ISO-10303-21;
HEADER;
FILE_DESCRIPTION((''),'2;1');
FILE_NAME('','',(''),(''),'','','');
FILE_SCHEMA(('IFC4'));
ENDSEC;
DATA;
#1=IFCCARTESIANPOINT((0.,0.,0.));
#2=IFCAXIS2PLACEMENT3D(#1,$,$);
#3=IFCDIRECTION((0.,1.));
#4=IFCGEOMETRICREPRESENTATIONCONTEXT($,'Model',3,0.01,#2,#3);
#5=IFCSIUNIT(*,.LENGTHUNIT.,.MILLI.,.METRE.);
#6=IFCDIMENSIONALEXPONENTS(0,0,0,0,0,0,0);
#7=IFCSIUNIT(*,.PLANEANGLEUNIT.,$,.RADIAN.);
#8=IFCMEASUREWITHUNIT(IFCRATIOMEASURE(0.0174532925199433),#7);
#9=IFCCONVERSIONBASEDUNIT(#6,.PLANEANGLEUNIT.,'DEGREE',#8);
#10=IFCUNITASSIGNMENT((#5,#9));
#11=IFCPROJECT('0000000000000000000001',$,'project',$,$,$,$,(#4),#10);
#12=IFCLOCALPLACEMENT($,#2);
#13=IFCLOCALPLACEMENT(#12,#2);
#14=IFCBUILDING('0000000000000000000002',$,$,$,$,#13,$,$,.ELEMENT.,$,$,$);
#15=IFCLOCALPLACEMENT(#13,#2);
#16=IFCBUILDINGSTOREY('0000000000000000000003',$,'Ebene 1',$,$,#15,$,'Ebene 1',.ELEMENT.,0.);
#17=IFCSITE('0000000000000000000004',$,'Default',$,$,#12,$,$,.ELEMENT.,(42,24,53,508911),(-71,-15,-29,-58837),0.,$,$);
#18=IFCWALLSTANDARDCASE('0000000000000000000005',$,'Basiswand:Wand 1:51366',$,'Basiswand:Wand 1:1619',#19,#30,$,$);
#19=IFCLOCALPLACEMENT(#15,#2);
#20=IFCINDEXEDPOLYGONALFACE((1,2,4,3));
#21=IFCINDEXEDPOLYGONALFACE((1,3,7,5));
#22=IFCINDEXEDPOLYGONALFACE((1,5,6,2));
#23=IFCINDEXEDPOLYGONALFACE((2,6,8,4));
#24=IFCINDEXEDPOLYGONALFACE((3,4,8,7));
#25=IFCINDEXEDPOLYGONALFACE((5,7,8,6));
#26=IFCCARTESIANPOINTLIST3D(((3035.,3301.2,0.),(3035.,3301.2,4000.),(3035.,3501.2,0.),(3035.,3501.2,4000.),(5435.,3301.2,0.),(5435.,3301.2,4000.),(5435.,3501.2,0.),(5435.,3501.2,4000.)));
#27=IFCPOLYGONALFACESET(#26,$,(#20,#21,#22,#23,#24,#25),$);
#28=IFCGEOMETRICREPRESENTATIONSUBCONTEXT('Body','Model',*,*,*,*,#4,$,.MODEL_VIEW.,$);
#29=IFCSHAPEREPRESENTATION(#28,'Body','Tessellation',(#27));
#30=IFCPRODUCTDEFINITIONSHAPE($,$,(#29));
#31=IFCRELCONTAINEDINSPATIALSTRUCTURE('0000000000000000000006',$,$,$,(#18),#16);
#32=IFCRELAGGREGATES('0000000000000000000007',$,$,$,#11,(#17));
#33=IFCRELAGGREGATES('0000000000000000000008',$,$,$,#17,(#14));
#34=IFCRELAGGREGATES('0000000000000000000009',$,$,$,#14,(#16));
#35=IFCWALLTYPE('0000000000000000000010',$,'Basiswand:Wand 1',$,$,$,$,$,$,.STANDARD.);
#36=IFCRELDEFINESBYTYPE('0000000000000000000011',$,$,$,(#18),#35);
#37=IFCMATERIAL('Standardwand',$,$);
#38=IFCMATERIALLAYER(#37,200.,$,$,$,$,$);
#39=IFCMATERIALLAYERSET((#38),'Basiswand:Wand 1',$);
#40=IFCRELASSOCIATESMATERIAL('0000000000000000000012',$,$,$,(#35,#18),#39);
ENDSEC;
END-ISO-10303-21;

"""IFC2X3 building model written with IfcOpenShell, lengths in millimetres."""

from ifc_helpers import new_model, entity, si_unit, converted_unit, direction, frame, frame_2d, origin, place, context, subcontext, project, spatial, rectangle, extrude, material, layer, layer_set, layer_usage, type_object, element, save


model = new_model("IFC2X3")

# Units and contexts
model_context = context("Model", 3, precision=0.01, world=origin(), true_north=direction((0.0, 1.0)))
body_context = subcontext(model_context, "Body", "Model", "MODEL_VIEW")
ifc_project = project(units=[si_unit("LENGTHUNIT", "METRE", prefix="MILLI"), converted_unit("PLANEANGLEUNIT", "DEGREE", entity("IfcRatioMeasure", 0.0174532925199433), si_unit("PLANEANGLEUNIT", "RADIAN"), dimensions=[0, 0, 0, 0, 0, 0, 0])], contexts=[model_context])

# Site, building, storey
site_placement = place(None, origin())
site = spatial("IfcSite", under=ifc_project, at=site_placement, Name="Default", CompositionType="ELEMENT", RefLatitude=(42, 24, 53, 508911), RefLongitude=(-71, -15, -29, -58837), RefElevation=0.0)
building_placement = place(site_placement, origin())
building = spatial("IfcBuilding", under=site, at=building_placement, CompositionType="ELEMENT")
storey_placement = place(building_placement, origin())
storey = spatial("IfcBuildingStorey", under=building, at=storey_placement, Name="Ebene 1", LongName="Ebene 1", CompositionType="ELEMENT", Elevation=0.0)

# Wall
ifc_material = material(Name="Standardwand")
ifc_layer = layer(ifc_material, 200.0)
ifc_layer_set = layer_set([ifc_layer], Name="Basiswand:Wand 1")
ifc_layer_usage = layer_usage(ifc_layer_set, "AXIS2", "NEGATIVE", 100.0)
wall_type = type_object("IfcWallType", Name="Basiswand:Wand 1", PredefinedType="STANDARD", material=ifc_layer_set)
wall_placement = place(storey_placement, frame((3035.0, 3401.2, 0.0)))
element("IfcWallStandardCase", 1, at=wall_placement, inside=storey, type_object=wall_type, material=ifc_layer_usage, Name="Basiswand:Wand 1:51366", ObjectType="Basiswand:Wand 1:1619", context=body_context, shape_type="SweptSolid", body=[
    extrude(rectangle(XDim=2400.0, YDim=200.0, at=frame_2d((1200.0, 0.0), x_axis=(-1.0, 0.0))), origin(), (0.0, 0.0, 1.0), 4000.0),
])

save(model, "model.ifc")
